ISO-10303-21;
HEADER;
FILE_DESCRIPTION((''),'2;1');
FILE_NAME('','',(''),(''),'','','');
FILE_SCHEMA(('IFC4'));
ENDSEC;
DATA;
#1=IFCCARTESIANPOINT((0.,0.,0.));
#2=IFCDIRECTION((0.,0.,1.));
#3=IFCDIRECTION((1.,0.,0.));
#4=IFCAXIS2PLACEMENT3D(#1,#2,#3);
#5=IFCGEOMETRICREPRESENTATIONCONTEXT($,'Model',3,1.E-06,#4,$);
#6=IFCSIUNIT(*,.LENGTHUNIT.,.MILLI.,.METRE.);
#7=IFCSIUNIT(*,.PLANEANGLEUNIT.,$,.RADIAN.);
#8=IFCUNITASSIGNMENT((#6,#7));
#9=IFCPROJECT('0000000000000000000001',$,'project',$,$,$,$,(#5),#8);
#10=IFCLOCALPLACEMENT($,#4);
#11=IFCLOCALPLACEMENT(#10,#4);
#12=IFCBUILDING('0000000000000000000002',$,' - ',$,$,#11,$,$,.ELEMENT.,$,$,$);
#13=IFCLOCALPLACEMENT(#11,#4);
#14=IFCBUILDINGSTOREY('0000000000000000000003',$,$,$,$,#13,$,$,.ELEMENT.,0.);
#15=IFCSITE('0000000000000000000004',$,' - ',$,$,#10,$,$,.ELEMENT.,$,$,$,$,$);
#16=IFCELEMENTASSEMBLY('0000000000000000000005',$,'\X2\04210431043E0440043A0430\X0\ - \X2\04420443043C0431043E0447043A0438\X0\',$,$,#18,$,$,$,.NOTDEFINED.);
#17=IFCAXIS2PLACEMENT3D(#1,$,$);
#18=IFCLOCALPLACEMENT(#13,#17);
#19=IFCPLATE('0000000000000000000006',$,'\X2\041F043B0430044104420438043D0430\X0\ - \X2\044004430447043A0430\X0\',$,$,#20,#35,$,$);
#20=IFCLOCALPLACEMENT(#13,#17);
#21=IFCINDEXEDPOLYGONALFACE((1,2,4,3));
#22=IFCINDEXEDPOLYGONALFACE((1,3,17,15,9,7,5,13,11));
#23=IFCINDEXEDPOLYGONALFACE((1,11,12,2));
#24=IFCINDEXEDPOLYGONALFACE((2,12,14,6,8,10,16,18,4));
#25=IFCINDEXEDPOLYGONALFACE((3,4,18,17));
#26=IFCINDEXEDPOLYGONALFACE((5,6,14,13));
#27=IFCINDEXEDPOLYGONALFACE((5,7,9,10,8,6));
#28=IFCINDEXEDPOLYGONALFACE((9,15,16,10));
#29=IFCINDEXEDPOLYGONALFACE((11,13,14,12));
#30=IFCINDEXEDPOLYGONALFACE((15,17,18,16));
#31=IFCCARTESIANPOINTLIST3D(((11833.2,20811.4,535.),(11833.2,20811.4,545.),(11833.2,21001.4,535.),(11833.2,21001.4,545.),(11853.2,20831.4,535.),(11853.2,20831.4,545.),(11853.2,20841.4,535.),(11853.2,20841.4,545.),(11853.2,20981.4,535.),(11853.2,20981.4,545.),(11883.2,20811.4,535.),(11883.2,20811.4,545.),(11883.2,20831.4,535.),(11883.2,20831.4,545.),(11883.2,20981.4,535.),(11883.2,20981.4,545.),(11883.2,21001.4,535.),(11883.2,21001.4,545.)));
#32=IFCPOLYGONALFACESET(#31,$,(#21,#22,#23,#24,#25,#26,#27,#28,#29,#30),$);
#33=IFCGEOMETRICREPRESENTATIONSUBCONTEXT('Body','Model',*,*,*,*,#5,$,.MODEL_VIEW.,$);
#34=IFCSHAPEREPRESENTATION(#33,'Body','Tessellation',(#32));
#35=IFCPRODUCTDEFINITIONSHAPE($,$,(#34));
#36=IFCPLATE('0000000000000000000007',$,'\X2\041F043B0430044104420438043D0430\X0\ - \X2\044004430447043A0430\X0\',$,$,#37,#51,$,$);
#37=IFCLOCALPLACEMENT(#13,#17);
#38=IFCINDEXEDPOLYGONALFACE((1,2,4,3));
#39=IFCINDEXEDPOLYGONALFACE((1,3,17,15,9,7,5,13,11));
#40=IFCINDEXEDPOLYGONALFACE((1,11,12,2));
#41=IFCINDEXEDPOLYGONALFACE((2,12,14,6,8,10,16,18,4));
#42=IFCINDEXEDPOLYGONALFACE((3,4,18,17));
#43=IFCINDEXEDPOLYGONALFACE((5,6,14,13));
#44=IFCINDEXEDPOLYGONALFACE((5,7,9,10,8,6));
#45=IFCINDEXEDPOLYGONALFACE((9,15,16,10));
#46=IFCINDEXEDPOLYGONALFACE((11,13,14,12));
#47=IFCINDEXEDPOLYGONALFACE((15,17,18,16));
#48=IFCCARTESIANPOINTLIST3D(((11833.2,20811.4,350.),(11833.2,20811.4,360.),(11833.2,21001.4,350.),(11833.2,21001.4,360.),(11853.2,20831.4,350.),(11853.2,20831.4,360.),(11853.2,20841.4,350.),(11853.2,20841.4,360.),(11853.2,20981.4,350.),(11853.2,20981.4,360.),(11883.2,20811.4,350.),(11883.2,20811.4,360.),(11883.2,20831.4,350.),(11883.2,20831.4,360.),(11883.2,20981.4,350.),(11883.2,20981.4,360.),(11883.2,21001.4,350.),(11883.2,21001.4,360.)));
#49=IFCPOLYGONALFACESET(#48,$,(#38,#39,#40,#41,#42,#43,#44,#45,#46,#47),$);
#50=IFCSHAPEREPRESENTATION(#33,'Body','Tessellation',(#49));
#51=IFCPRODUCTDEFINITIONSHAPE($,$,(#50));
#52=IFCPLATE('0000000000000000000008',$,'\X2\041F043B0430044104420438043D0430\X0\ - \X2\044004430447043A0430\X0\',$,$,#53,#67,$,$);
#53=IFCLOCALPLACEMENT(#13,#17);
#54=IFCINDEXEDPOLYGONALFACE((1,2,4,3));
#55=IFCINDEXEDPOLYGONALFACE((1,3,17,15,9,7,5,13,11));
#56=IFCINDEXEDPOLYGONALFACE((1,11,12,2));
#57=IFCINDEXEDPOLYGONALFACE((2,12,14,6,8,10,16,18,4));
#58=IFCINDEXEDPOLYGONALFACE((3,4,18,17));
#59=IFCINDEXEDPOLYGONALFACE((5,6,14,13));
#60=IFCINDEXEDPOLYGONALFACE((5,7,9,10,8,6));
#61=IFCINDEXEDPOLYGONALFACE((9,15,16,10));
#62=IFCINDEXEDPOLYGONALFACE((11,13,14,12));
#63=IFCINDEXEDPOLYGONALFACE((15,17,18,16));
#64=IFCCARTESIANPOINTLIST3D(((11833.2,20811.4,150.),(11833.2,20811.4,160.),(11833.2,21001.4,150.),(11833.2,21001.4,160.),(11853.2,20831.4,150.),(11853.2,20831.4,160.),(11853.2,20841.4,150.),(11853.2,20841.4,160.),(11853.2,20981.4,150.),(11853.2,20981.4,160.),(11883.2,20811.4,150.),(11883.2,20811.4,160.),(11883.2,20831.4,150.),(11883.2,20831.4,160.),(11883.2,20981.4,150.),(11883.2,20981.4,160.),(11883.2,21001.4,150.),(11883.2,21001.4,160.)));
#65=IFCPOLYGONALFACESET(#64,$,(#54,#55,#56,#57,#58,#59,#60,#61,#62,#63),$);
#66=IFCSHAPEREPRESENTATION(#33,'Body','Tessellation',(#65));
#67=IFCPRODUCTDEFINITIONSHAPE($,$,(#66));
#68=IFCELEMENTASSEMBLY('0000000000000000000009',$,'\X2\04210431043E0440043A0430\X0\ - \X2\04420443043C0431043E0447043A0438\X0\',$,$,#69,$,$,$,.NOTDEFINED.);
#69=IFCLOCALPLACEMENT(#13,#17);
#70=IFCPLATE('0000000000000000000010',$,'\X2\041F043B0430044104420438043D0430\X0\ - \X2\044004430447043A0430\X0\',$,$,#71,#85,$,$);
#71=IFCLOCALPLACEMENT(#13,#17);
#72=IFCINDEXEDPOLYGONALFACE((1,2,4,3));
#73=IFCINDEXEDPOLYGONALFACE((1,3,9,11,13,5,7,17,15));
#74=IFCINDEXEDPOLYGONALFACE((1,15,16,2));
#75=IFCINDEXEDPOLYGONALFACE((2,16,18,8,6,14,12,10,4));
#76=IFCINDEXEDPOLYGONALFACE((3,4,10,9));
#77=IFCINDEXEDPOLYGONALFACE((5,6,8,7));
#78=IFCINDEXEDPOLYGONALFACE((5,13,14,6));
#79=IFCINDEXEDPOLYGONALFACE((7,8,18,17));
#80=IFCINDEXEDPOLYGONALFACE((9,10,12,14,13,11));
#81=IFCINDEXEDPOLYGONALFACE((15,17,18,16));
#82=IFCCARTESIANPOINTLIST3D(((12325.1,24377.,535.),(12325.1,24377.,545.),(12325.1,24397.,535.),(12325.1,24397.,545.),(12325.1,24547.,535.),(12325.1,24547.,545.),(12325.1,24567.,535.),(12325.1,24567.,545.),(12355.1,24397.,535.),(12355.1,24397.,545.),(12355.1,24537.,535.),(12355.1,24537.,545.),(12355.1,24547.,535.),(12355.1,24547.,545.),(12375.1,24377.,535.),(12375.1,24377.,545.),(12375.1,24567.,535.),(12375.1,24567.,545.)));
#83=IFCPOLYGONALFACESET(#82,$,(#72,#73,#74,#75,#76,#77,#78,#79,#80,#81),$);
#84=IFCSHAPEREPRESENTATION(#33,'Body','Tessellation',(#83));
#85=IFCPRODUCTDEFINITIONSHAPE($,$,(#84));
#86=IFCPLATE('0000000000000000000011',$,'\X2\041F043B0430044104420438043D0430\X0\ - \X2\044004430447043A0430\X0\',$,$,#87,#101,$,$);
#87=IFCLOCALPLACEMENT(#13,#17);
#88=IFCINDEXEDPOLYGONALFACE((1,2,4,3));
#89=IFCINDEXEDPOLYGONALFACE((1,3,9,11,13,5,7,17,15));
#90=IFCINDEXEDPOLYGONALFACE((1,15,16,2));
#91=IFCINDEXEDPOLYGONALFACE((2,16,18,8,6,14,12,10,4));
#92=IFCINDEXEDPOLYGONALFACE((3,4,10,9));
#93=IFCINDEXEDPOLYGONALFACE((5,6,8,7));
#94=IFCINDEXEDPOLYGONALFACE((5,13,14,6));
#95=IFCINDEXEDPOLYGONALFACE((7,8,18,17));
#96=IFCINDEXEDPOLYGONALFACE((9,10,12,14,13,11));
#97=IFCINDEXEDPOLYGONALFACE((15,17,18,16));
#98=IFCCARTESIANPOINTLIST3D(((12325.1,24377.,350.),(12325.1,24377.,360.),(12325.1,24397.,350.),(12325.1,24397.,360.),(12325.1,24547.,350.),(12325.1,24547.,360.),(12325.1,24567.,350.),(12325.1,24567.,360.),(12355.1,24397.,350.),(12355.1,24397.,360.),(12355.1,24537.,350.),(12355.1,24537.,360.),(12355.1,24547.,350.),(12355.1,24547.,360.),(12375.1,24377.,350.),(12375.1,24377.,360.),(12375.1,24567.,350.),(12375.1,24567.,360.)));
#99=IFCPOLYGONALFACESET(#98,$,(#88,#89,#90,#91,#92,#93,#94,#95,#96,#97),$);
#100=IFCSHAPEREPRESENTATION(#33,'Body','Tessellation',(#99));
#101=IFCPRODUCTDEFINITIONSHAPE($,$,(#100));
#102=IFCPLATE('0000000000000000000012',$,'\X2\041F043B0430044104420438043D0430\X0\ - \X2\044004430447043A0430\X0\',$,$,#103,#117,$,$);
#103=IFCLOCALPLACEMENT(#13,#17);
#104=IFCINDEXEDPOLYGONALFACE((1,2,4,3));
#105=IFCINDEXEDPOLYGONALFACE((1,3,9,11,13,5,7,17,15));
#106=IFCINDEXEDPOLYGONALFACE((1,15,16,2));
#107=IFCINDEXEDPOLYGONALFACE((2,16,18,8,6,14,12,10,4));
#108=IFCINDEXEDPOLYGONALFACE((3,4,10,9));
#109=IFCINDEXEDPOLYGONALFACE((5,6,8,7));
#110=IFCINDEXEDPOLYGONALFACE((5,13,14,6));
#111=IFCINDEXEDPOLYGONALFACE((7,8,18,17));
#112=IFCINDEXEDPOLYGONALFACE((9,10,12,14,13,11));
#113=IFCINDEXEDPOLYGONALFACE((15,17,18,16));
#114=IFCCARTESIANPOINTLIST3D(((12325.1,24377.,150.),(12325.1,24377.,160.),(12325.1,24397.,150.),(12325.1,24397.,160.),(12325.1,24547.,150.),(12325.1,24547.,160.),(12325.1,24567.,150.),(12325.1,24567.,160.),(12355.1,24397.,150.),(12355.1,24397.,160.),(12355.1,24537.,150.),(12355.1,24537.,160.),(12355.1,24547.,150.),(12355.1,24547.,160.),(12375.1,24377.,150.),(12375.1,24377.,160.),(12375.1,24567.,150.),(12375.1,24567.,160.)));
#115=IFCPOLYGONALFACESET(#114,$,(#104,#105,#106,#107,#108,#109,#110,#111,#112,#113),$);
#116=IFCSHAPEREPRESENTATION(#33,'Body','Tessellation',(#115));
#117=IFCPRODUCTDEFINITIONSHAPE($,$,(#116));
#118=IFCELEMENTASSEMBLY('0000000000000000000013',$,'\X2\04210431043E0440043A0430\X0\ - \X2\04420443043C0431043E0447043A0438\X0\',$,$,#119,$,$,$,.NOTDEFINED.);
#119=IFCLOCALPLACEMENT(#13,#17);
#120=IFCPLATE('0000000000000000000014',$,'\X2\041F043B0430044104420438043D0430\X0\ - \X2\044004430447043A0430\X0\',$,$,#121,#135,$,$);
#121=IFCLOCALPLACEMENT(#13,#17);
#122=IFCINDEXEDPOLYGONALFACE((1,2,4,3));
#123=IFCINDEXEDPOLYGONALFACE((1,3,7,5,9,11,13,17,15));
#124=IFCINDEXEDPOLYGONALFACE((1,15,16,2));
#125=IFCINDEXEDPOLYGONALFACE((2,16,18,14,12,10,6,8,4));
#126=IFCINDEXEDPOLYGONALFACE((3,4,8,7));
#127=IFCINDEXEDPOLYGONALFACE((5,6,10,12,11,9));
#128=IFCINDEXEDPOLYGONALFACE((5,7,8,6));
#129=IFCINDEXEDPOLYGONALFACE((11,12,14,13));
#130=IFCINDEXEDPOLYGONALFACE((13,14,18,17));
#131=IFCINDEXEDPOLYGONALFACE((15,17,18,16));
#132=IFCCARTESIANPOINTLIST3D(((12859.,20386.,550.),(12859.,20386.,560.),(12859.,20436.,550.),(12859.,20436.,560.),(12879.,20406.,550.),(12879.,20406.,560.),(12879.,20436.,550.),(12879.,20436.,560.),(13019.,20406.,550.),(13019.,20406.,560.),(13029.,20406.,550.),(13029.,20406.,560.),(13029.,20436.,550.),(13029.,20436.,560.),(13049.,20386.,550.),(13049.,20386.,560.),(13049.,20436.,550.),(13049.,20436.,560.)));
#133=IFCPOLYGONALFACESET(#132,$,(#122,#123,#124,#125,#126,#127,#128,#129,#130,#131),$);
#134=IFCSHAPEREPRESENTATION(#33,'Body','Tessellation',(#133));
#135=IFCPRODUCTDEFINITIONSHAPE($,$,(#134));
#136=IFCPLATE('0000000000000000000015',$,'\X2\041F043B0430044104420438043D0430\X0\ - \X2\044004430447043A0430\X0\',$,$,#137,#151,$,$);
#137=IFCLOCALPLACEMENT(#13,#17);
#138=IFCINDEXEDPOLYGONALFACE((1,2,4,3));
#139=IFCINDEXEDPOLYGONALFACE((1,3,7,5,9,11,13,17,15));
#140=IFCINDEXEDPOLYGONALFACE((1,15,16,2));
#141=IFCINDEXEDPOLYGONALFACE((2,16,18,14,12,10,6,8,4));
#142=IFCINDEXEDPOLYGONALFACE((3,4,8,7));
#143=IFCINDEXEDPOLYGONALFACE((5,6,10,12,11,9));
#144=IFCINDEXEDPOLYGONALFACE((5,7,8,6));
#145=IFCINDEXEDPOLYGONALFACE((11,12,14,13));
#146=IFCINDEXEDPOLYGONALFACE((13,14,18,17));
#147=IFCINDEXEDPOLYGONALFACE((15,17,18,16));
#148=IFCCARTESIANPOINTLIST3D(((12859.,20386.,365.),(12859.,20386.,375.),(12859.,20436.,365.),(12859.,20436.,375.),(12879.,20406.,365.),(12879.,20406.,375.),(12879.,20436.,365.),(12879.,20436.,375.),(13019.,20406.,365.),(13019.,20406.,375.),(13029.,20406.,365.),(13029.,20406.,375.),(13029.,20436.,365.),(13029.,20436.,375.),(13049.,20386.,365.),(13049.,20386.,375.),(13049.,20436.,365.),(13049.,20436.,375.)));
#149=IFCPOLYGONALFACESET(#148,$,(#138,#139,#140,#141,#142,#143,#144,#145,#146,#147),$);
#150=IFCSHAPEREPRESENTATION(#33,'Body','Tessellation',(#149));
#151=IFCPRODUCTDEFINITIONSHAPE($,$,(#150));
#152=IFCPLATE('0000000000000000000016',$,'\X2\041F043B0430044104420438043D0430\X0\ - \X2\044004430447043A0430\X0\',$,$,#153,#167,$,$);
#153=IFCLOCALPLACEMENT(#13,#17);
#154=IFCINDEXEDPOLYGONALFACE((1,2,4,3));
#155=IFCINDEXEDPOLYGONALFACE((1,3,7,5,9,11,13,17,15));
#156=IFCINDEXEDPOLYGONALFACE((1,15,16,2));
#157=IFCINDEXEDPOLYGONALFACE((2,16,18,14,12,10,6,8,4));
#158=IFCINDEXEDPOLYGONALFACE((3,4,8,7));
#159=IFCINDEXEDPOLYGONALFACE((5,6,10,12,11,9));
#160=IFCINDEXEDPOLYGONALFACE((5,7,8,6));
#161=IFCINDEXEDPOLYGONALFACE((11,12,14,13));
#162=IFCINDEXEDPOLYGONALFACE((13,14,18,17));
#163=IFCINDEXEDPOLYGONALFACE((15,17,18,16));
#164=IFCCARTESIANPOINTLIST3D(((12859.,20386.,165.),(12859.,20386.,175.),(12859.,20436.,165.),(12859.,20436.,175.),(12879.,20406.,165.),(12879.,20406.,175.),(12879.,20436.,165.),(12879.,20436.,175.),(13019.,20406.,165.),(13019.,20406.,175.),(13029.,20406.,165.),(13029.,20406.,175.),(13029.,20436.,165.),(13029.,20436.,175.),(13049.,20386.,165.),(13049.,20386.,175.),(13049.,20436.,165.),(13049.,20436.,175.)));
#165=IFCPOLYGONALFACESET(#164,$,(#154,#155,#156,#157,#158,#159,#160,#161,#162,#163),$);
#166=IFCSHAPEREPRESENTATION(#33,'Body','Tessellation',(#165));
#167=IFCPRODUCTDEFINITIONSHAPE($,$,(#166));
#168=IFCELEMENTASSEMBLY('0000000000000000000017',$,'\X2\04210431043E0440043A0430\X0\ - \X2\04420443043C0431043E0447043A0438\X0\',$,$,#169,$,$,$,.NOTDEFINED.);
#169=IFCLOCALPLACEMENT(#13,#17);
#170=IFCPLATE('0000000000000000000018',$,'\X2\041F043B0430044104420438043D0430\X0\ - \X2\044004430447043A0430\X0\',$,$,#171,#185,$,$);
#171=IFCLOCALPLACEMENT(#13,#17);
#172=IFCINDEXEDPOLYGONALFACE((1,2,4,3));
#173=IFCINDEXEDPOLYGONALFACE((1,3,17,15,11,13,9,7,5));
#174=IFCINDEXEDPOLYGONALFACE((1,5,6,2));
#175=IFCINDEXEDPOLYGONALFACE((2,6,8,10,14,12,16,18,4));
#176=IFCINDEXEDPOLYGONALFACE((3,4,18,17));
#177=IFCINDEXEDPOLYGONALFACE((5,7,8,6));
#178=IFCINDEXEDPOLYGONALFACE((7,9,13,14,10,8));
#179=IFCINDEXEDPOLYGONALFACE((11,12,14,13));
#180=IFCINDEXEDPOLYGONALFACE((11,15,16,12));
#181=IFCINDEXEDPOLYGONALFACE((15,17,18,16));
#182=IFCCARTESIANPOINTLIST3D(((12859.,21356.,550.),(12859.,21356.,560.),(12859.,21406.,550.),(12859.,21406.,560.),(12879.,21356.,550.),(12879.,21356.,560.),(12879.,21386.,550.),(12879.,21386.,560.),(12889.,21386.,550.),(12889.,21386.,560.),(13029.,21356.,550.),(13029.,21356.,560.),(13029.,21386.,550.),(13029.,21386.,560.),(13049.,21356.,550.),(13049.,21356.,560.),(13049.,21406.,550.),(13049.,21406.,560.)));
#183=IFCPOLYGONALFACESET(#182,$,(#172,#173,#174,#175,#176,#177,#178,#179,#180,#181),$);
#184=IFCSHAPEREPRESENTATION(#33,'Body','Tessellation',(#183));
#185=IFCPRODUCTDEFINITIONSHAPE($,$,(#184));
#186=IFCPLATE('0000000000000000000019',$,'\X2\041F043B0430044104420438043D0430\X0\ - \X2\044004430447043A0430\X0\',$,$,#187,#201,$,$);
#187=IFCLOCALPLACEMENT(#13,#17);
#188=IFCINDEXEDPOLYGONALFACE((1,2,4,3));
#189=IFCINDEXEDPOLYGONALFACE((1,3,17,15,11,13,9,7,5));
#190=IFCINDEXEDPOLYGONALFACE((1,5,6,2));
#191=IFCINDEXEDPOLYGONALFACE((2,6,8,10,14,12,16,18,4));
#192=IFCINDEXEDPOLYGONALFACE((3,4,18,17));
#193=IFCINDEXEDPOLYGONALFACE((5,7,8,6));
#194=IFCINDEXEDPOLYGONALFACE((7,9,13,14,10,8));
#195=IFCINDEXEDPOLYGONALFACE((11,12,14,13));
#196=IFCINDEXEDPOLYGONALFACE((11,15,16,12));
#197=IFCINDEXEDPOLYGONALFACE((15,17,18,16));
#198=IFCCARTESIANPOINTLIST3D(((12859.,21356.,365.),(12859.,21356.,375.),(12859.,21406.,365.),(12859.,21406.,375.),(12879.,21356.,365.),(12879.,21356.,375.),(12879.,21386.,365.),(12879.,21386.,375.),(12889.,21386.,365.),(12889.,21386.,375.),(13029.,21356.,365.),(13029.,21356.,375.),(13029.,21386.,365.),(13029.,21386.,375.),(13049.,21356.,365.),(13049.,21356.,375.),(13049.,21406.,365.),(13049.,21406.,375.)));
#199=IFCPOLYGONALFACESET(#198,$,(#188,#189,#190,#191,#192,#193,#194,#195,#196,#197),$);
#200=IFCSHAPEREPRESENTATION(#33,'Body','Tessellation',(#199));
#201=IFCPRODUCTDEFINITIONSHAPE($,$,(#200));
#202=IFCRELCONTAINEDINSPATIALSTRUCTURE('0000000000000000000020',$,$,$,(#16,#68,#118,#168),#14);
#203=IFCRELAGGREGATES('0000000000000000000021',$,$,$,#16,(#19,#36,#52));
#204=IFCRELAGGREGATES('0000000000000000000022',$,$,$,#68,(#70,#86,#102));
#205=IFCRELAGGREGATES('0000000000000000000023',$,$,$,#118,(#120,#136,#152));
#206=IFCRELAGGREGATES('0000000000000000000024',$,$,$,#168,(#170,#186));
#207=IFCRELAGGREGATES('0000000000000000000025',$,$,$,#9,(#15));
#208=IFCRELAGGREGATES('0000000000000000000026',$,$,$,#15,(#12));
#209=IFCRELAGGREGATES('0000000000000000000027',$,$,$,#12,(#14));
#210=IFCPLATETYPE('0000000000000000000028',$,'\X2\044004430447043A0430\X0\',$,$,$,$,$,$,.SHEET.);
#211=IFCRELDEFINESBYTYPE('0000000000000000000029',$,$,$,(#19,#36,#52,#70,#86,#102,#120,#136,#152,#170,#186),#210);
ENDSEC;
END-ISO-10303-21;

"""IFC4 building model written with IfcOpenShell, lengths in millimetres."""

from ifc_helpers import new_model, si_unit, frame, origin_with_axes, place, context, subcontext, project, spatial, line, indexed_curve, outline, extrude, source, transform, mapped, type_object, element, aggregate, save


model = new_model("IFC4")

# Units and contexts
model_context = context("Model", 3, precision=1e-06, world=origin_with_axes())
body_context = subcontext(model_context, "Body", "Model", "MODEL_VIEW")
ifc_project = project(units=[si_unit("LENGTHUNIT", "METRE", prefix="MILLI"), si_unit("PLANEANGLEUNIT", "RADIAN")], contexts=[model_context])

# Site, building, storey
site_placement = place(None, origin_with_axes())
site = spatial("IfcSite", under=ifc_project, at=site_placement, Name=" - ", CompositionType="ELEMENT")
building_placement = place(site_placement, origin_with_axes())
building = spatial("IfcBuilding", under=site, at=building_placement, Name=" - ", CompositionType="ELEMENT")
storey_placement = place(building_placement, origin_with_axes())
storey = spatial("IfcBuildingStorey", under=building, at=storey_placement, CompositionType="ELEMENT", Elevation=0.0)

# Shared definitions
plate_type_1 = type_object("IfcPlateType", Name="ручка", PredefinedType="SHEET")
shared_shape_1 = source(origin_with_axes(), body_context, "Body", "SweptSolid", [
    extrude(outline(indexed_curve([(-95.0, -25.0), (-75.0, -25.0), (-75.0, 5.0), (-65.0, 5.0), (75.0, 5.0), (75.0, -25.0), (95.0, -25.0), (95.0, 25.0), (-95.0, 25.0)], segments=[line(1, 2), line(2, 3), line(3, 4), line(4, 5), line(5, 6), line(6, 7), line(7, 8), line(8, 9), line(9, 1)])), origin_with_axes(), (0.0, 0.0, 1.0), 10.0),
])

# Element assemblies, plates
assembly_1_placement = place(storey_placement, frame((11883.2, 21106.4, 0.0), z_axis=(0.0, 0.0, 1.0), x_axis=(0.0, -1.0, 0.0)))
assembly_1 = element("IfcElementAssembly", 1, at=assembly_1_placement, inside=storey, Name="Сборка - тумбочки", PredefinedType="NOTDEFINED")
plate_1_placement = place(assembly_1_placement, frame((200.0, -25.0, 535.0), z_axis=(0.0, 0.0, 1.0), x_axis=(-1.0, 0.0, 0.0)))
plate_1 = element("IfcPlate", 2, at=plate_1_placement, type_object=plate_type_1, Name="Пластина - ручка", context=body_context, shape_type="MappedRepresentation", body=[
    mapped(shared_shape_1, transform((0.0, 0.0, 0.0), x_axis=(1.0, 0.0, 0.0), y_axis=(0.0, 1.0, 0.0), z_axis=(0.0, 0.0, 1.0), scale=1.0)),
])
plate_2_placement = place(assembly_1_placement, frame((200.0, -25.0, 350.0), z_axis=(0.0, 0.0, 1.0), x_axis=(-1.0, 0.0, 0.0)))
plate_2 = element("IfcPlate", 3, at=plate_2_placement, type_object=plate_type_1, Name="Пластина - ручка", context=body_context, shape_type="MappedRepresentation", body=[
    mapped(shared_shape_1, transform((0.0, 0.0, 0.0), x_axis=(1.0, 0.0, 0.0), y_axis=(0.0, 1.0, 0.0), z_axis=(0.0, 0.0, 1.0), scale=1.0)),
])
plate_3_placement = place(assembly_1_placement, frame((200.0, -25.0, 150.0), z_axis=(0.0, 0.0, 1.0), x_axis=(-1.0, 0.0, 0.0)))
plate_3 = element("IfcPlate", 4, at=plate_3_placement, type_object=plate_type_1, Name="Пластина - ручка", context=body_context, shape_type="MappedRepresentation", body=[
    mapped(shared_shape_1, transform((0.0, 0.0, 0.0), x_axis=(1.0, 0.0, 0.0), y_axis=(0.0, 1.0, 0.0), z_axis=(0.0, 0.0, 1.0), scale=1.0)),
])
aggregate(assembly_1, [plate_1, plate_2, plate_3])
assembly_2_placement = place(storey_placement, frame((12325.1, 24272.0, 0.0), z_axis=(0.0, 0.0, 1.0), x_axis=(0.0, 1.0, 0.0)))
assembly_2 = element("IfcElementAssembly", 5, at=assembly_2_placement, inside=storey, Name="Сборка - тумбочки", PredefinedType="NOTDEFINED")
plate_4_placement = place(assembly_2_placement, frame((200.0, -25.0, 535.0), z_axis=(0.0, 0.0, 1.0), x_axis=(-1.0, 0.0, 0.0)))
plate_4 = element("IfcPlate", 6, at=plate_4_placement, type_object=plate_type_1, Name="Пластина - ручка", context=body_context, shape_type="MappedRepresentation", body=[
    mapped(shared_shape_1, transform((0.0, 0.0, 0.0), x_axis=(1.0, 0.0, 0.0), y_axis=(0.0, 1.0, 0.0), z_axis=(0.0, 0.0, 1.0), scale=1.0)),
])
plate_5_placement = place(assembly_2_placement, frame((200.0, -25.0, 350.0), z_axis=(0.0, 0.0, 1.0), x_axis=(-1.0, 0.0, 0.0)))
plate_5 = element("IfcPlate", 7, at=plate_5_placement, type_object=plate_type_1, Name="Пластина - ручка", context=body_context, shape_type="MappedRepresentation", body=[
    mapped(shared_shape_1, transform((0.0, 0.0, 0.0), x_axis=(1.0, 0.0, 0.0), y_axis=(0.0, 1.0, 0.0), z_axis=(0.0, 0.0, 1.0), scale=1.0)),
])
plate_6_placement = place(assembly_2_placement, frame((200.0, -25.0, 150.0), z_axis=(0.0, 0.0, 1.0), x_axis=(-1.0, 0.0, 0.0)))
plate_6 = element("IfcPlate", 8, at=plate_6_placement, type_object=plate_type_1, Name="Пластина - ручка", context=body_context, shape_type="MappedRepresentation", body=[
    mapped(shared_shape_1, transform((0.0, 0.0, 0.0), x_axis=(1.0, 0.0, 0.0), y_axis=(0.0, 1.0, 0.0), z_axis=(0.0, 0.0, 1.0), scale=1.0)),
])
aggregate(assembly_2, [plate_4, plate_5, plate_6])
assembly_3_placement = place(storey_placement, frame((12754.0, 20436.0, 15.0), z_axis=(0.0, 0.0, 1.0), x_axis=(1.0, 0.0, 0.0)))
assembly_3 = element("IfcElementAssembly", 9, at=assembly_3_placement, inside=storey, Name="Сборка - тумбочки", PredefinedType="NOTDEFINED")
plate_7_placement = place(assembly_3_placement, frame((200.0, -25.0, 535.0), z_axis=(0.0, 0.0, 1.0), x_axis=(-1.0, 0.0, 0.0)))
plate_7 = element("IfcPlate", 10, at=plate_7_placement, type_object=plate_type_1, Name="Пластина - ручка", context=body_context, shape_type="MappedRepresentation", body=[
    mapped(shared_shape_1, transform((0.0, 0.0, 0.0), x_axis=(1.0, 0.0, 0.0), y_axis=(0.0, 1.0, 0.0), z_axis=(0.0, 0.0, 1.0), scale=1.0)),
])
plate_8_placement = place(assembly_3_placement, frame((200.0, -25.0, 350.0), z_axis=(0.0, 0.0, 1.0), x_axis=(-1.0, 0.0, 0.0)))
plate_8 = element("IfcPlate", 11, at=plate_8_placement, type_object=plate_type_1, Name="Пластина - ручка", context=body_context, shape_type="MappedRepresentation", body=[
    mapped(shared_shape_1, transform((0.0, 0.0, 0.0), x_axis=(1.0, 0.0, 0.0), y_axis=(0.0, 1.0, 0.0), z_axis=(0.0, 0.0, 1.0), scale=1.0)),
])
plate_9_placement = place(assembly_3_placement, frame((200.0, -25.0, 150.0), z_axis=(0.0, 0.0, 1.0), x_axis=(-1.0, 0.0, 0.0)))
plate_9 = element("IfcPlate", 12, at=plate_9_placement, type_object=plate_type_1, Name="Пластина - ручка", context=body_context, shape_type="MappedRepresentation", body=[
    mapped(shared_shape_1, transform((0.0, 0.0, 0.0), x_axis=(1.0, 0.0, 0.0), y_axis=(0.0, 1.0, 0.0), z_axis=(0.0, 0.0, 1.0), scale=1.0)),
])
aggregate(assembly_3, [plate_7, plate_8, plate_9])
assembly_4_placement = place(storey_placement, frame((13154.0, 21356.0, 15.0), z_axis=(0.0, 0.0, 1.0), x_axis=(-1.0, 0.0, 0.0)))
assembly_4 = element("IfcElementAssembly", 13, at=assembly_4_placement, inside=storey, Name="Сборка - тумбочки", PredefinedType="NOTDEFINED")
plate_10_placement = place(assembly_4_placement, frame((200.0, -25.0, 535.0), z_axis=(0.0, 0.0, 1.0), x_axis=(-1.0, 0.0, 0.0)))
plate_10 = element("IfcPlate", 14, at=plate_10_placement, type_object=plate_type_1, Name="Пластина - ручка", context=body_context, shape_type="MappedRepresentation", body=[
    mapped(shared_shape_1, transform((0.0, 0.0, 0.0), x_axis=(1.0, 0.0, 0.0), y_axis=(0.0, 1.0, 0.0), z_axis=(0.0, 0.0, 1.0), scale=1.0)),
])
plate_11_placement = place(assembly_4_placement, frame((200.0, -25.0, 350.0), z_axis=(0.0, 0.0, 1.0), x_axis=(-1.0, 0.0, 0.0)))
plate_11 = element("IfcPlate", 15, at=plate_11_placement, type_object=plate_type_1, Name="Пластина - ручка", context=body_context, shape_type="MappedRepresentation", body=[
    mapped(shared_shape_1, transform((0.0, 0.0, 0.0), x_axis=(1.0, 0.0, 0.0), y_axis=(0.0, 1.0, 0.0), z_axis=(0.0, 0.0, 1.0), scale=1.0)),
])
aggregate(assembly_4, [plate_10, plate_11])

save(model, "model.ifc")
